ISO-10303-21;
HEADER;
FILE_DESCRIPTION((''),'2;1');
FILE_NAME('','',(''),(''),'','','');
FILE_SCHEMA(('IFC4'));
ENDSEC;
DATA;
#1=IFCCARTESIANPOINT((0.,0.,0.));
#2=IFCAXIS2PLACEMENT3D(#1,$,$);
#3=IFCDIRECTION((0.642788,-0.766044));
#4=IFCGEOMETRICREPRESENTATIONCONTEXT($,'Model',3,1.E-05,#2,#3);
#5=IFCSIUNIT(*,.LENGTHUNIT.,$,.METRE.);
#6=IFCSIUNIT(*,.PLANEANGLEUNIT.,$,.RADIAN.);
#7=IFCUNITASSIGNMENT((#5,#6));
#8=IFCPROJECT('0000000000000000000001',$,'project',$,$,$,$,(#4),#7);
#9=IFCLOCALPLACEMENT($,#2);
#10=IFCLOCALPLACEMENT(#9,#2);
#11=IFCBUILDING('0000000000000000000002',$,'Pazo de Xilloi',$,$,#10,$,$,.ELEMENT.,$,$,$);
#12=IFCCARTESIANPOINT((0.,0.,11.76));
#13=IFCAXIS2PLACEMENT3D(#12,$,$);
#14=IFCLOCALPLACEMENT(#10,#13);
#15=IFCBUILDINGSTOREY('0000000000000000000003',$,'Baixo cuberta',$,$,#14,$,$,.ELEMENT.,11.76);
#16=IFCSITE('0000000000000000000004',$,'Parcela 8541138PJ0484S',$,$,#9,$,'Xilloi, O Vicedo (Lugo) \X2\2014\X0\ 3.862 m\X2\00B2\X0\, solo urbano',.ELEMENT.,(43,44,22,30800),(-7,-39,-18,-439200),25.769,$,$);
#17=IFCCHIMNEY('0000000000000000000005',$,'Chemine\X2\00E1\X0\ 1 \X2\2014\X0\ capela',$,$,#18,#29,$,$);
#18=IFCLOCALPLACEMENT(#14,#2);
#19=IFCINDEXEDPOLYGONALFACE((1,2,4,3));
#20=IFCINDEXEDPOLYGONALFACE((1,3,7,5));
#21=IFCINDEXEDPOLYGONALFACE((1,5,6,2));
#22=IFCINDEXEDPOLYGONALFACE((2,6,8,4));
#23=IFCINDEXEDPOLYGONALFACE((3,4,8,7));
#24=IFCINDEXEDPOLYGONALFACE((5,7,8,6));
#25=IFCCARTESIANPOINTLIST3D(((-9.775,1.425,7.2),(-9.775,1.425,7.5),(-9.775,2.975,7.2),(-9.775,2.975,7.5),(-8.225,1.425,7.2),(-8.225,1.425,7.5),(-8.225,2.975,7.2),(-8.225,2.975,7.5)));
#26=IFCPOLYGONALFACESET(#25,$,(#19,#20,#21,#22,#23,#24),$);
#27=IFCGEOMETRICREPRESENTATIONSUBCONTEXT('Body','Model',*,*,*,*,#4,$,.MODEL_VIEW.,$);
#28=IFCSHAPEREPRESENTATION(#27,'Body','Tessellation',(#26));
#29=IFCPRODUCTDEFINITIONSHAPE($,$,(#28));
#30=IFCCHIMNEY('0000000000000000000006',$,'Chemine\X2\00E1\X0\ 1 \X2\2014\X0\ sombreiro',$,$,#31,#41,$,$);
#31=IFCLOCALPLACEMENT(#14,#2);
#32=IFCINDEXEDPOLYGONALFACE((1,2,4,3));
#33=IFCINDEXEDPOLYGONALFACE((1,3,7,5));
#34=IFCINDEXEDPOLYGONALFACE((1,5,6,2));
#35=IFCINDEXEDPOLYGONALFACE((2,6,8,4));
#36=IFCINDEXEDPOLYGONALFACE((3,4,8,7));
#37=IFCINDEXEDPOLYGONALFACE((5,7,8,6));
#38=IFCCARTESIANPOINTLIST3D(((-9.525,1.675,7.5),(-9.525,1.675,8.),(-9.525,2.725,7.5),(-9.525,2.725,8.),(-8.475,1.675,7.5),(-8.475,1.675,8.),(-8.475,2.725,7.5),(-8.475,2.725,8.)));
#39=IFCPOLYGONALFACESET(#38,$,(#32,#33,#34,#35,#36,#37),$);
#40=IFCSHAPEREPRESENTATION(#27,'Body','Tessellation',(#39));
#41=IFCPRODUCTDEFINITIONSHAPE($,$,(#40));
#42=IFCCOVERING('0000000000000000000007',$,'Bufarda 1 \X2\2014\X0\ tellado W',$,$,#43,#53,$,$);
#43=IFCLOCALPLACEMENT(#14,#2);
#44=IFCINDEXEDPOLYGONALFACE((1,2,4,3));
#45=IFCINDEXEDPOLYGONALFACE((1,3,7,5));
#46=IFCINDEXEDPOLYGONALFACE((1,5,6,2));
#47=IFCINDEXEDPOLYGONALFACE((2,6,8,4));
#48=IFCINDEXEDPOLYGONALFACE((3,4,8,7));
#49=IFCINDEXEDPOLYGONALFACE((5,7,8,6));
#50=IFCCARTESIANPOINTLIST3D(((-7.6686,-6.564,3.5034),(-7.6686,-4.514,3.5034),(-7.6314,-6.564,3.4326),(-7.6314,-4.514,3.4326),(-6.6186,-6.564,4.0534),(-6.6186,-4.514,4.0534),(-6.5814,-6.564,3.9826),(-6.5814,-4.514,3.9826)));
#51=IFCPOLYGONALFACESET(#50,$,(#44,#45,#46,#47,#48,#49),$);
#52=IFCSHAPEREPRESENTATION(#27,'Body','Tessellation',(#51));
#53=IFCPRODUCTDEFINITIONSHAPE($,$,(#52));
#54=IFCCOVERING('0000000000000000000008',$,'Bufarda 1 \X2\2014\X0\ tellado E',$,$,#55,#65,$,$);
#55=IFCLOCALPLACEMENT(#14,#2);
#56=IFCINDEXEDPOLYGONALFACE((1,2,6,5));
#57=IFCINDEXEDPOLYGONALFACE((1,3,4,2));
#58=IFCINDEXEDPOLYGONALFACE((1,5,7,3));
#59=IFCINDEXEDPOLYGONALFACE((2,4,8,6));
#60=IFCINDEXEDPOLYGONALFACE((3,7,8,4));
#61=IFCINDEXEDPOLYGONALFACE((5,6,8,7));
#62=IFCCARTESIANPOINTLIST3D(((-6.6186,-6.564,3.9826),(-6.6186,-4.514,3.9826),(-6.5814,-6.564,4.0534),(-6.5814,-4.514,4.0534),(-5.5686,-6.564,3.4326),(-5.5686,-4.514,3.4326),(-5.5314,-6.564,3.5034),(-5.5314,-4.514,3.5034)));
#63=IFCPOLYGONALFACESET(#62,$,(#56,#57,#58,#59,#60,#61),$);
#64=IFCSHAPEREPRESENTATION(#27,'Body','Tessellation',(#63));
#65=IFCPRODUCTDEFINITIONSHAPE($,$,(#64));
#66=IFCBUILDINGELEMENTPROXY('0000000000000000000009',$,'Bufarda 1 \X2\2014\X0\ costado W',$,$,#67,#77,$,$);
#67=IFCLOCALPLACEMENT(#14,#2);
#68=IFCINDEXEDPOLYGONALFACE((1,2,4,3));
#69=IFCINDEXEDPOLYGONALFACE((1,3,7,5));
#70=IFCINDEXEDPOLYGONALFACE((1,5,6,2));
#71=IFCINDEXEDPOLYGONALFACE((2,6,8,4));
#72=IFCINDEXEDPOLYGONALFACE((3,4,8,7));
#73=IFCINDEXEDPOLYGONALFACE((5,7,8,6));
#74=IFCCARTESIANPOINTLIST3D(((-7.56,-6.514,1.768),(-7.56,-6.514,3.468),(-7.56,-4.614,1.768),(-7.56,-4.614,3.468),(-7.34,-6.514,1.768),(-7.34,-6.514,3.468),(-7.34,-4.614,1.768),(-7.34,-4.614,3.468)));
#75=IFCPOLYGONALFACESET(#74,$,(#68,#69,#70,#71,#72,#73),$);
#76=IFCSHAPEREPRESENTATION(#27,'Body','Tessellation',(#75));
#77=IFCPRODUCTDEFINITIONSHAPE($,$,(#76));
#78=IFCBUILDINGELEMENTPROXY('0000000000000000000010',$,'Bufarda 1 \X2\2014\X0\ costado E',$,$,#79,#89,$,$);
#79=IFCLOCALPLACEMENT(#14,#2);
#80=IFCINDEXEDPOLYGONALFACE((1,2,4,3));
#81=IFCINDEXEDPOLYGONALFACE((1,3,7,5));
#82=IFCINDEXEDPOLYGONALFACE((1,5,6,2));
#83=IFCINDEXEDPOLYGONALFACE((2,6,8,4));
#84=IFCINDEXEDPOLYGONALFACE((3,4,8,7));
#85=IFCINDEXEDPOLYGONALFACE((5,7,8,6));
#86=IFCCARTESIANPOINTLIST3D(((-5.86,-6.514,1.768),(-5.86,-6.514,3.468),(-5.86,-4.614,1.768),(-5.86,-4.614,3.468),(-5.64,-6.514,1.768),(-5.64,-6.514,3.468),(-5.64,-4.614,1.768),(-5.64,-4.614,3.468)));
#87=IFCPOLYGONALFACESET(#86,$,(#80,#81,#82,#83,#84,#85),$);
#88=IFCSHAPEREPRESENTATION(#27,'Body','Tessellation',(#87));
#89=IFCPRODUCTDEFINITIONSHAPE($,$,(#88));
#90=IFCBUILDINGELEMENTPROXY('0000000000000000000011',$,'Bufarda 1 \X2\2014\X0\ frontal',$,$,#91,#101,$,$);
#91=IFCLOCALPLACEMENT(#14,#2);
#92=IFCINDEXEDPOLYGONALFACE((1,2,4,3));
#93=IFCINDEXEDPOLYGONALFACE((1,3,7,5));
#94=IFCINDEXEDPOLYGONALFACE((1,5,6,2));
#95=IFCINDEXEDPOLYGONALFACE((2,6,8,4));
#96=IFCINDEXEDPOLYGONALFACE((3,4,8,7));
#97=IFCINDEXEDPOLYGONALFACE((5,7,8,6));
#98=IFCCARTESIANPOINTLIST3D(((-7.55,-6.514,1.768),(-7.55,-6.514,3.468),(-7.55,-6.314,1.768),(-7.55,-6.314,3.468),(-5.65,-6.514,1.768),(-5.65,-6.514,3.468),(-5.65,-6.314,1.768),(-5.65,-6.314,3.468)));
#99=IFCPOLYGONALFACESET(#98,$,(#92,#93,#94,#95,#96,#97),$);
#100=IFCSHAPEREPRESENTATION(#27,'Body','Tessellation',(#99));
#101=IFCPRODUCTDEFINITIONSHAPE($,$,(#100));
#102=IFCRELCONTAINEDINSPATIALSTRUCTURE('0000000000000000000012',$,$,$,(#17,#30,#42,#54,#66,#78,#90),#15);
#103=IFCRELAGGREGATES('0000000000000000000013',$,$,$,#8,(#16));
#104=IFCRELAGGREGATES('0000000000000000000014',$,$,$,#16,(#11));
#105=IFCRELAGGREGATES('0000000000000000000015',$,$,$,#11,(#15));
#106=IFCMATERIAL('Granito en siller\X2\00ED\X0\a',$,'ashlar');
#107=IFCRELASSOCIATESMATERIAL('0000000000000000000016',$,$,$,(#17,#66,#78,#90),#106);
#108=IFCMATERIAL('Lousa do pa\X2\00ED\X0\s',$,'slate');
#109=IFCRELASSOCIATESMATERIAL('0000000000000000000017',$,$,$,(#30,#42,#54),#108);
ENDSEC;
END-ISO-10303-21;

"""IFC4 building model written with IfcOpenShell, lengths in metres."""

from ifc_helpers import new_model, si_unit, direction, frame, origin, origin_2d, place, context, subcontext, project, spatial, polyline, rectangle, outline, extrude, material, element, save


model = new_model("IFC4")

# Units and contexts
model_context = context("Model", 3, precision=1e-05, world=origin(), true_north=direction((0.642788, -0.766044)))
body_context = subcontext(model_context, "Body", "Model", "MODEL_VIEW")
ifc_project = project(units=[si_unit("LENGTHUNIT", "METRE"), si_unit("PLANEANGLEUNIT", "RADIAN")], contexts=[model_context])

# Site, building, storey
site_placement = place(None, origin())
site = spatial("IfcSite", under=ifc_project, at=site_placement, Name="Parcela 8541138PJ0484S", LongName="Xilloi, O Vicedo (Lugo) — 3.862 m², solo urbano", CompositionType="ELEMENT", RefLatitude=(43, 44, 22, 30800), RefLongitude=(-7, -39, -18, -439200), RefElevation=25.769)
building_placement = place(site_placement, origin())
building = spatial("IfcBuilding", under=site, at=building_placement, Name="Pazo de Xilloi", CompositionType="ELEMENT")
storey_placement = place(building_placement, frame((0.0, 0.0, 11.76)))
storey = spatial("IfcBuildingStorey", under=building, at=storey_placement, Name="Baixo cuberta", CompositionType="ELEMENT", Elevation=11.76)

# Chimneys
ifc_material_1 = material(Name="Granito en sillería", Category="ashlar")
chimney_1_placement = place(storey_placement, frame((-9.0, 2.2, 7.35)))
element("IfcChimney", 1, at=chimney_1_placement, inside=storey, material=ifc_material_1, Name="Chemineá 1 — capela", context=body_context, shape_type="SweptSolid", body=[
    extrude(rectangle(XDim=1.55, YDim=1.55, at=origin_2d()), frame((0.0, 0.0, -0.15)), (0.0, 0.0, 1.0), 0.3),
])
ifc_material_2 = material(Name="Lousa do país", Category="slate")
chimney_2_placement = place(storey_placement, frame((-9.0, 2.2, 7.75)))
element("IfcChimney", 2, at=chimney_2_placement, inside=storey, material=ifc_material_2, Name="Chemineá 1 — sombreiro", context=body_context, shape_type="SweptSolid", body=[
    extrude(rectangle(XDim=1.05, YDim=1.05, at=origin_2d()), frame((0.0, 0.0, -0.25)), (0.0, 0.0, 1.0), 0.5),
])

# Coverings
covering_1_placement = place(storey_placement, frame((-7.125, -5.539, 3.743), z_axis=(-0.464007, 0.0, 0.885832), x_axis=(0.0, -1.0, 0.0)))
element("IfcCovering", 3, at=covering_1_placement, inside=storey, material=ifc_material_2, Name="Bufarda 1 — tellado W", context=body_context, shape_type="SweptSolid", body=[
    extrude(outline(polyline([(1.025, -0.5927), (1.025, 0.5927), (-1.025, 0.5927), (-1.025, -0.5927), (1.025, -0.5927)])), frame((0.0, 0.0, -0.04)), (0.0, 0.0, 1.0), 0.08),
])
covering_2_placement = place(storey_placement, frame((-6.075, -5.539, 3.743), z_axis=(-0.464007, 0.0, -0.885832), x_axis=(0.0, -1.0, 0.0)))
element("IfcCovering", 4, at=covering_2_placement, inside=storey, material=ifc_material_2, Name="Bufarda 1 — tellado E", context=body_context, shape_type="SweptSolid", body=[
    extrude(outline(polyline([(1.025, -0.5927), (1.025, 0.5927), (-1.025, 0.5927), (-1.025, -0.5927), (1.025, -0.5927)])), frame((0.0, 0.0, -0.04)), (0.0, 0.0, 1.0), 0.08),
])

# Building element proxies
for number, where, name in (
    (5, (-7.45, -5.564, 2.618), "Bufarda 1 — costado W"),
    (6, (-5.75, -5.564, 2.618), "Bufarda 1 — costado E"),
):
    element("IfcBuildingElementProxy", number, at=place(storey_placement, frame(where)), inside=storey, material=ifc_material_1, Name=name, context=body_context, shape_type="SweptSolid", body=[
        extrude(rectangle(XDim=0.22, YDim=1.9, at=origin_2d()), frame((0.0, 0.0, -0.85)), (0.0, 0.0, 1.0), 1.7),
    ])
proxy_placement = place(storey_placement, frame((-6.6, -6.414, 2.618)))
element("IfcBuildingElementProxy", 7, at=proxy_placement, inside=storey, material=ifc_material_1, Name="Bufarda 1 — frontal", context=body_context, shape_type="SweptSolid", body=[
    extrude(rectangle(XDim=1.9, YDim=0.2, at=origin_2d()), frame((0.0, 0.0, -0.85)), (0.0, 0.0, 1.0), 1.7),
])

save(model, "model.ifc")
